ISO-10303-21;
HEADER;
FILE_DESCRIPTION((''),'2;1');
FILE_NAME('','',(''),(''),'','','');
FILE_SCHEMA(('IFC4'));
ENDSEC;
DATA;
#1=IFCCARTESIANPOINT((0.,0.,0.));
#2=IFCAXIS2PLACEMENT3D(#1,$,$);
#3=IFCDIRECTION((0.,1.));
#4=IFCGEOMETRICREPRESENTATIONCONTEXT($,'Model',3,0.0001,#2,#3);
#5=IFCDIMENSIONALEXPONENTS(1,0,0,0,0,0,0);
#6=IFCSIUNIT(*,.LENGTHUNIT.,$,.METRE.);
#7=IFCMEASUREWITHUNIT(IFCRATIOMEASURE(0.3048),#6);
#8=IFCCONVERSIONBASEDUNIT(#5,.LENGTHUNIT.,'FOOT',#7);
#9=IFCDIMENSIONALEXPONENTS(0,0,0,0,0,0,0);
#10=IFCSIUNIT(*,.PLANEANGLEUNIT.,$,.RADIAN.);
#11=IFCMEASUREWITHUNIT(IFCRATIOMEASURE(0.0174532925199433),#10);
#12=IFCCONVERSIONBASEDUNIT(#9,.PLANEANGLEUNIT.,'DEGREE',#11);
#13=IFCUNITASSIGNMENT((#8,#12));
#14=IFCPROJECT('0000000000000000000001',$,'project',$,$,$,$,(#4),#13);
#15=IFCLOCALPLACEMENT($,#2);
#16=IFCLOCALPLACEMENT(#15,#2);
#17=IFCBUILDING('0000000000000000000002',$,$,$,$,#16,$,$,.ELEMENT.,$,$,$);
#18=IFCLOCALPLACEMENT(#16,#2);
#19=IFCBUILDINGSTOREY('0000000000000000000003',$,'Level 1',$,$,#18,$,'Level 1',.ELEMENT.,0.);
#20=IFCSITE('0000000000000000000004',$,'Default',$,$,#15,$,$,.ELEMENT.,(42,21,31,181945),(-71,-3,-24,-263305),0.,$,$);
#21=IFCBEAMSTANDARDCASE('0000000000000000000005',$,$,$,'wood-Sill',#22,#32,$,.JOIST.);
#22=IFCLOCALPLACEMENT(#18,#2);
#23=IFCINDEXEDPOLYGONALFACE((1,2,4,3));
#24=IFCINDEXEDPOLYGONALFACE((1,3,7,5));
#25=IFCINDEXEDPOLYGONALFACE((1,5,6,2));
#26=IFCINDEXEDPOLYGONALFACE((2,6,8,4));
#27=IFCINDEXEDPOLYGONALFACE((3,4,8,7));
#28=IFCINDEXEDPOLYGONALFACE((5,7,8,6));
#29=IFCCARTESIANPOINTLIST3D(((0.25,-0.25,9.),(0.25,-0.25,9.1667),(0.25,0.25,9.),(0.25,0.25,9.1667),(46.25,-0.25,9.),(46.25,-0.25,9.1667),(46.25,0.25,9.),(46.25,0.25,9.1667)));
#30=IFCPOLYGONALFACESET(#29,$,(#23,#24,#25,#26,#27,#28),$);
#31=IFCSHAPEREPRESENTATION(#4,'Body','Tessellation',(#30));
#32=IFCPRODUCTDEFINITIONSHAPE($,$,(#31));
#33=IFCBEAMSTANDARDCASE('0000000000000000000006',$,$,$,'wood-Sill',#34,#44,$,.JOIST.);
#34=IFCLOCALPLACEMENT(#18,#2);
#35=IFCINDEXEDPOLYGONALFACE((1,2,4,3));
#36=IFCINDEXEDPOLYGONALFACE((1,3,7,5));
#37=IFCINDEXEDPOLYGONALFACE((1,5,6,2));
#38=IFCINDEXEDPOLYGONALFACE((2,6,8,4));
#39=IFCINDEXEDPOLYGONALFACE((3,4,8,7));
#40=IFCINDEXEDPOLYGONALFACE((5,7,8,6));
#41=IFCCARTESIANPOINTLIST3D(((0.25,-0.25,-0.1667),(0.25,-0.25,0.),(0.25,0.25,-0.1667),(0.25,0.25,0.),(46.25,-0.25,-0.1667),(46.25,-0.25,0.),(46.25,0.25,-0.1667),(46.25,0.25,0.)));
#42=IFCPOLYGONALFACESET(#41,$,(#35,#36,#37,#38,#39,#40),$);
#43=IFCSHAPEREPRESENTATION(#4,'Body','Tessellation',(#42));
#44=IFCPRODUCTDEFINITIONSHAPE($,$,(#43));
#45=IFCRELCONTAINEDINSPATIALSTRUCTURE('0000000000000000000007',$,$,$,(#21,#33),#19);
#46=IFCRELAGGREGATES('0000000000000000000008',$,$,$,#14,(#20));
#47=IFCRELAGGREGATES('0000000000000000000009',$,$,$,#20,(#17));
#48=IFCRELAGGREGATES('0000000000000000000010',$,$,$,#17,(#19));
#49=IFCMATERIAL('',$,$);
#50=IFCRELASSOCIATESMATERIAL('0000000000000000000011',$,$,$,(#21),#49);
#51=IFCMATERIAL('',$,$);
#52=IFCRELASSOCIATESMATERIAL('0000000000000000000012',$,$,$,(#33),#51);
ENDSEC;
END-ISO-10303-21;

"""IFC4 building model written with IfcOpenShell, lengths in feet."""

from ifc_helpers import new_model, entity, si_unit, converted_unit, direction, frame, origin, place, context, project, spatial, rectangle, extrude, material, element, save


model = new_model("IFC4")

# Units and contexts
model_context = context("Model", 3, precision=0.0001, world=origin(), true_north=direction((0.0, 1.0)))
ifc_project = project(units=[converted_unit("LENGTHUNIT", "FOOT", entity("IfcRatioMeasure", 0.3048), si_unit("LENGTHUNIT", "METRE"), dimensions=[1, 0, 0, 0, 0, 0, 0]), converted_unit("PLANEANGLEUNIT", "DEGREE", entity("IfcRatioMeasure", 0.0174532925199433), si_unit("PLANEANGLEUNIT", "RADIAN"), dimensions=[0, 0, 0, 0, 0, 0, 0])], contexts=[model_context])

# Site, building, storey
site_placement = place(None, origin())
site = spatial("IfcSite", under=ifc_project, at=site_placement, Name="Default", CompositionType="ELEMENT", RefLatitude=(42, 21, 31, 181945), RefLongitude=(-71, -3, -24, -263305), RefElevation=0.0)
building_placement = place(site_placement, origin())
building = spatial("IfcBuilding", under=site, at=building_placement, CompositionType="ELEMENT")
storey_placement = place(building_placement, origin())
storey = spatial("IfcBuildingStorey", under=building, at=storey_placement, Name="Level 1", LongName="Level 1", CompositionType="ELEMENT", Elevation=0.0)

# Shared definitions
placement = place(storey_placement, frame((46.25, 0.0, 0.0), z_axis=(0.0, 0.0, 1.0), x_axis=(-1.0, 0.0, 0.0)))

# Beams
ifc_material_1 = material(Name="")
beam_1_placement = place(placement, frame((23.0, 0.0, 9.0), z_axis=(0.0, 0.0, 1.0), x_axis=(1.0, 0.0, 0.0)))
element("IfcBeamStandardCase", 1, at=beam_1_placement, inside=storey, material=ifc_material_1, ObjectType="wood-Sill", PredefinedType="JOIST", context=model_context, shape_type="SweptSolid", body=[
    extrude(rectangle(XDim=46.0, YDim=0.5), origin(), (0.0, 0.0, 1.0), 0.1667),
])
ifc_material_2 = material(Name="")
beam_2_placement = place(placement, frame((23.0, 0.0, -0.1667), z_axis=(0.0, 0.0, 1.0), x_axis=(1.0, 0.0, 0.0)))
element("IfcBeamStandardCase", 2, at=beam_2_placement, inside=storey, material=ifc_material_2, ObjectType="wood-Sill", PredefinedType="JOIST", context=model_context, shape_type="SweptSolid", body=[
    extrude(rectangle(XDim=46.0, YDim=0.5), origin(), (0.0, 0.0, 1.0), 0.1667),
])

save(model, "model.ifc")
